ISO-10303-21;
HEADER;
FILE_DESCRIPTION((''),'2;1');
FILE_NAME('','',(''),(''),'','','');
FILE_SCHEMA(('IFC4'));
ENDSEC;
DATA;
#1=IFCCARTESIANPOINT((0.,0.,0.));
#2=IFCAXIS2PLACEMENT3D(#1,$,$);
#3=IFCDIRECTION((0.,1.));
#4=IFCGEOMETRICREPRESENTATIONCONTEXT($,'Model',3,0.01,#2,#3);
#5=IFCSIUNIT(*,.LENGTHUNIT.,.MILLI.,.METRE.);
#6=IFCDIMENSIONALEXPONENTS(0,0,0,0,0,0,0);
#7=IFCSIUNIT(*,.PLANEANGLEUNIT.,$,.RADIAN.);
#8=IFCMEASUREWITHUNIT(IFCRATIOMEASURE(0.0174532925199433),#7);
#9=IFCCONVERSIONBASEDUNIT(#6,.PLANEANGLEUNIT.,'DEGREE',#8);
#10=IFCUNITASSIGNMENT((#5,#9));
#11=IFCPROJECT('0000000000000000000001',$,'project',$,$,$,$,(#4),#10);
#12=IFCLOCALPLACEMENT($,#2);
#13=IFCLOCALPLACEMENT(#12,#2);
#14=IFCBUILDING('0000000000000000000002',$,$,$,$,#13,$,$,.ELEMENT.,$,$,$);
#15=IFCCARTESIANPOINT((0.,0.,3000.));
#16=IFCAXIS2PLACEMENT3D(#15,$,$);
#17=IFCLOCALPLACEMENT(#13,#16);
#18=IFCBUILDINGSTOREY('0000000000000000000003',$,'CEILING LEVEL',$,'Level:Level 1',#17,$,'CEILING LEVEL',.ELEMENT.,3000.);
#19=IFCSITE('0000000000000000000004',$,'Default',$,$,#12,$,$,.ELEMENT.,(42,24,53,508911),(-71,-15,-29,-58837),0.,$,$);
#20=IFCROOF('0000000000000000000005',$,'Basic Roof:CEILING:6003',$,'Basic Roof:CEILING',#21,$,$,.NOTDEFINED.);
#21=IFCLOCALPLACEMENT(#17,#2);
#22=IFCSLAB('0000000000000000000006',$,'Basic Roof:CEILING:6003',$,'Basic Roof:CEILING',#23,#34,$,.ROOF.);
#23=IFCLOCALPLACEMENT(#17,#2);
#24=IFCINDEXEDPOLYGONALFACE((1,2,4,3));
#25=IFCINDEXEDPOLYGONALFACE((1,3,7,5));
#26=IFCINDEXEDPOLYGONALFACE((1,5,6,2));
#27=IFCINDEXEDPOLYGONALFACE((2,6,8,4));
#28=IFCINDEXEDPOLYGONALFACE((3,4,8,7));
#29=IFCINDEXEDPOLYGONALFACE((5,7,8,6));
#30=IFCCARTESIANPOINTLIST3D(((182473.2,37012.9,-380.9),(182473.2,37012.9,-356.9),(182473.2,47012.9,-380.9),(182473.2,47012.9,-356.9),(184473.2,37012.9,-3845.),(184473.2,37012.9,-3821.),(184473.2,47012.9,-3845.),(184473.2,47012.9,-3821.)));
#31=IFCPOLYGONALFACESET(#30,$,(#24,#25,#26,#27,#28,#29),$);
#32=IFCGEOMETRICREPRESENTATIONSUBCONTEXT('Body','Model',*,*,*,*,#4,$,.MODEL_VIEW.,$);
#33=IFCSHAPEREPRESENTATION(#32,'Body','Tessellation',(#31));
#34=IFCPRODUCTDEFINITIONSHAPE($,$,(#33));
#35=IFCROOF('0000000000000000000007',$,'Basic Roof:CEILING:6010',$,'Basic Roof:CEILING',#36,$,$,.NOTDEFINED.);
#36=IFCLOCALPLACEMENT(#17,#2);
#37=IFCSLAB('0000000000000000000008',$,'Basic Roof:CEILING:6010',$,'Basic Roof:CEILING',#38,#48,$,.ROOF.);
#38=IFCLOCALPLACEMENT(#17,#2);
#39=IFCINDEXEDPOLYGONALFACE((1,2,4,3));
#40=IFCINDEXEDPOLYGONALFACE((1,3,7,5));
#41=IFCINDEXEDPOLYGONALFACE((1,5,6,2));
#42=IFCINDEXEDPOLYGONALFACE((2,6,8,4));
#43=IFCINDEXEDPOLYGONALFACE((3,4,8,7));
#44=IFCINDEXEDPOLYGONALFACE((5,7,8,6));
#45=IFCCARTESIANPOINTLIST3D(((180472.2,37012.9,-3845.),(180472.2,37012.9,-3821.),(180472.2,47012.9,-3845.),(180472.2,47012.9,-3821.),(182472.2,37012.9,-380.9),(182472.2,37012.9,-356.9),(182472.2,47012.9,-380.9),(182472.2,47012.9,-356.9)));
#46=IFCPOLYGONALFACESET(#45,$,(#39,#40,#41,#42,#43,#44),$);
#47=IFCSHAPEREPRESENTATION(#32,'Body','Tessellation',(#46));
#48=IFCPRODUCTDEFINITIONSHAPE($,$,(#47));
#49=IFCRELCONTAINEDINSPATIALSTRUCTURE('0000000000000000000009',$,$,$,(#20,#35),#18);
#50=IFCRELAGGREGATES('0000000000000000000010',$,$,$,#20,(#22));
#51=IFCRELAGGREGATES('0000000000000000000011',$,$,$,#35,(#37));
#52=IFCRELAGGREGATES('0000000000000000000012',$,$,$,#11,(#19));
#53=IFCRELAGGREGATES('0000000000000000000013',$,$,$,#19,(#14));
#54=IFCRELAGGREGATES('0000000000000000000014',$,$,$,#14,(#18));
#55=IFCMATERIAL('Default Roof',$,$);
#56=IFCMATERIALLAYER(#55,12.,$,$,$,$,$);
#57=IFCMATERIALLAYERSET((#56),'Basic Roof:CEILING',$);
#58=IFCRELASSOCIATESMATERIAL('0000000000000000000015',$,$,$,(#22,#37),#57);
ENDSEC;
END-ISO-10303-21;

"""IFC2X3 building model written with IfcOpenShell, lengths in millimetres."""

from ifc_helpers import new_model, entity, si_unit, converted_unit, direction, frame, frame_2d, origin, place, context, subcontext, project, spatial, rectangle, extrude, material, layer, layer_set, element, aggregate, save


model = new_model("IFC2X3")

# Units and contexts
model_context = context("Model", 3, precision=0.01, world=origin(), true_north=direction((0.0, 1.0)))
body_context = subcontext(model_context, "Body", "Model", "MODEL_VIEW")
ifc_project = project(units=[si_unit("LENGTHUNIT", "METRE", prefix="MILLI"), converted_unit("PLANEANGLEUNIT", "DEGREE", entity("IfcRatioMeasure", 0.0174532925199433), si_unit("PLANEANGLEUNIT", "RADIAN"), dimensions=[0, 0, 0, 0, 0, 0, 0])], contexts=[model_context])

# Site, building, storey
site_placement = place(None, origin())
site = spatial("IfcSite", under=ifc_project, at=site_placement, Name="Default", CompositionType="ELEMENT", RefLatitude=(42, 24, 53, 508911), RefLongitude=(-71, -15, -29, -58837), RefElevation=0.0)
building_placement = place(site_placement, origin())
building = spatial("IfcBuilding", under=site, at=building_placement, CompositionType="ELEMENT")
storey_placement = place(building_placement, frame((0.0, 0.0, 3000.0)))
storey = spatial("IfcBuildingStorey", under=building, at=storey_placement, Name="CEILING LEVEL", ObjectType="Level:Level 1", LongName="CEILING LEVEL", CompositionType="ELEMENT", Elevation=3000.0)

# Roofs, slabs
roof_1_placement = place(storey_placement, frame((182473.2, 37012.9, -3845.0)))
roof_1 = element("IfcRoof", 1, at=roof_1_placement, inside=storey, Name="Basic Roof:CEILING:6003", ObjectType="Basic Roof:CEILING", ShapeType="NOTDEFINED")
ifc_material = material(Name="Default Roof")
ifc_layer = layer(ifc_material, 12.0)
ifc_layer_set = layer_set([ifc_layer], Name="Basic Roof:CEILING")
slab_1_placement = place(roof_1_placement, origin())
slab_1 = element("IfcSlab", 2, at=slab_1_placement, material=ifc_layer_set, Name="Basic Roof:CEILING:6003", ObjectType="Basic Roof:CEILING", PredefinedType="ROOF", context=body_context, shape_type="SweptSolid", body=[
    extrude(rectangle(XDim=4000.0, YDim=10000.0, at=frame_2d((0.0, 0.0), x_axis=(-1.0, 0.0))), frame((1000.0, 5000.0, 1732.1), z_axis=(0.866025, 0.0, 0.5), x_axis=(0.5, 0.0, -0.866025)), (-0.866025, 0.0, 0.5), 24.0),
])
aggregate(roof_1, [slab_1])
roof_2_placement = place(storey_placement, frame((180472.2, 37012.9, -3845.0)))
roof_2 = element("IfcRoof", 3, at=roof_2_placement, inside=storey, Name="Basic Roof:CEILING:6010", ObjectType="Basic Roof:CEILING", ShapeType="NOTDEFINED")
slab_2_placement = place(roof_2_placement, origin())
slab_2 = element("IfcSlab", 4, at=slab_2_placement, material=ifc_layer_set, Name="Basic Roof:CEILING:6010", ObjectType="Basic Roof:CEILING", PredefinedType="ROOF", context=body_context, shape_type="SweptSolid", body=[
    extrude(rectangle(XDim=4000.0, YDim=10000.0, at=frame_2d((0.0, 0.0), x_axis=(-1.0, 0.0))), frame((1000.0, 5000.0, 1732.1), z_axis=(-0.866025, 0.0, 0.5), x_axis=(0.5, 0.0, 0.866025)), (0.866025, 0.0, 0.5), 24.0),
])
aggregate(roof_2, [slab_2])

save(model, "model.ifc")
